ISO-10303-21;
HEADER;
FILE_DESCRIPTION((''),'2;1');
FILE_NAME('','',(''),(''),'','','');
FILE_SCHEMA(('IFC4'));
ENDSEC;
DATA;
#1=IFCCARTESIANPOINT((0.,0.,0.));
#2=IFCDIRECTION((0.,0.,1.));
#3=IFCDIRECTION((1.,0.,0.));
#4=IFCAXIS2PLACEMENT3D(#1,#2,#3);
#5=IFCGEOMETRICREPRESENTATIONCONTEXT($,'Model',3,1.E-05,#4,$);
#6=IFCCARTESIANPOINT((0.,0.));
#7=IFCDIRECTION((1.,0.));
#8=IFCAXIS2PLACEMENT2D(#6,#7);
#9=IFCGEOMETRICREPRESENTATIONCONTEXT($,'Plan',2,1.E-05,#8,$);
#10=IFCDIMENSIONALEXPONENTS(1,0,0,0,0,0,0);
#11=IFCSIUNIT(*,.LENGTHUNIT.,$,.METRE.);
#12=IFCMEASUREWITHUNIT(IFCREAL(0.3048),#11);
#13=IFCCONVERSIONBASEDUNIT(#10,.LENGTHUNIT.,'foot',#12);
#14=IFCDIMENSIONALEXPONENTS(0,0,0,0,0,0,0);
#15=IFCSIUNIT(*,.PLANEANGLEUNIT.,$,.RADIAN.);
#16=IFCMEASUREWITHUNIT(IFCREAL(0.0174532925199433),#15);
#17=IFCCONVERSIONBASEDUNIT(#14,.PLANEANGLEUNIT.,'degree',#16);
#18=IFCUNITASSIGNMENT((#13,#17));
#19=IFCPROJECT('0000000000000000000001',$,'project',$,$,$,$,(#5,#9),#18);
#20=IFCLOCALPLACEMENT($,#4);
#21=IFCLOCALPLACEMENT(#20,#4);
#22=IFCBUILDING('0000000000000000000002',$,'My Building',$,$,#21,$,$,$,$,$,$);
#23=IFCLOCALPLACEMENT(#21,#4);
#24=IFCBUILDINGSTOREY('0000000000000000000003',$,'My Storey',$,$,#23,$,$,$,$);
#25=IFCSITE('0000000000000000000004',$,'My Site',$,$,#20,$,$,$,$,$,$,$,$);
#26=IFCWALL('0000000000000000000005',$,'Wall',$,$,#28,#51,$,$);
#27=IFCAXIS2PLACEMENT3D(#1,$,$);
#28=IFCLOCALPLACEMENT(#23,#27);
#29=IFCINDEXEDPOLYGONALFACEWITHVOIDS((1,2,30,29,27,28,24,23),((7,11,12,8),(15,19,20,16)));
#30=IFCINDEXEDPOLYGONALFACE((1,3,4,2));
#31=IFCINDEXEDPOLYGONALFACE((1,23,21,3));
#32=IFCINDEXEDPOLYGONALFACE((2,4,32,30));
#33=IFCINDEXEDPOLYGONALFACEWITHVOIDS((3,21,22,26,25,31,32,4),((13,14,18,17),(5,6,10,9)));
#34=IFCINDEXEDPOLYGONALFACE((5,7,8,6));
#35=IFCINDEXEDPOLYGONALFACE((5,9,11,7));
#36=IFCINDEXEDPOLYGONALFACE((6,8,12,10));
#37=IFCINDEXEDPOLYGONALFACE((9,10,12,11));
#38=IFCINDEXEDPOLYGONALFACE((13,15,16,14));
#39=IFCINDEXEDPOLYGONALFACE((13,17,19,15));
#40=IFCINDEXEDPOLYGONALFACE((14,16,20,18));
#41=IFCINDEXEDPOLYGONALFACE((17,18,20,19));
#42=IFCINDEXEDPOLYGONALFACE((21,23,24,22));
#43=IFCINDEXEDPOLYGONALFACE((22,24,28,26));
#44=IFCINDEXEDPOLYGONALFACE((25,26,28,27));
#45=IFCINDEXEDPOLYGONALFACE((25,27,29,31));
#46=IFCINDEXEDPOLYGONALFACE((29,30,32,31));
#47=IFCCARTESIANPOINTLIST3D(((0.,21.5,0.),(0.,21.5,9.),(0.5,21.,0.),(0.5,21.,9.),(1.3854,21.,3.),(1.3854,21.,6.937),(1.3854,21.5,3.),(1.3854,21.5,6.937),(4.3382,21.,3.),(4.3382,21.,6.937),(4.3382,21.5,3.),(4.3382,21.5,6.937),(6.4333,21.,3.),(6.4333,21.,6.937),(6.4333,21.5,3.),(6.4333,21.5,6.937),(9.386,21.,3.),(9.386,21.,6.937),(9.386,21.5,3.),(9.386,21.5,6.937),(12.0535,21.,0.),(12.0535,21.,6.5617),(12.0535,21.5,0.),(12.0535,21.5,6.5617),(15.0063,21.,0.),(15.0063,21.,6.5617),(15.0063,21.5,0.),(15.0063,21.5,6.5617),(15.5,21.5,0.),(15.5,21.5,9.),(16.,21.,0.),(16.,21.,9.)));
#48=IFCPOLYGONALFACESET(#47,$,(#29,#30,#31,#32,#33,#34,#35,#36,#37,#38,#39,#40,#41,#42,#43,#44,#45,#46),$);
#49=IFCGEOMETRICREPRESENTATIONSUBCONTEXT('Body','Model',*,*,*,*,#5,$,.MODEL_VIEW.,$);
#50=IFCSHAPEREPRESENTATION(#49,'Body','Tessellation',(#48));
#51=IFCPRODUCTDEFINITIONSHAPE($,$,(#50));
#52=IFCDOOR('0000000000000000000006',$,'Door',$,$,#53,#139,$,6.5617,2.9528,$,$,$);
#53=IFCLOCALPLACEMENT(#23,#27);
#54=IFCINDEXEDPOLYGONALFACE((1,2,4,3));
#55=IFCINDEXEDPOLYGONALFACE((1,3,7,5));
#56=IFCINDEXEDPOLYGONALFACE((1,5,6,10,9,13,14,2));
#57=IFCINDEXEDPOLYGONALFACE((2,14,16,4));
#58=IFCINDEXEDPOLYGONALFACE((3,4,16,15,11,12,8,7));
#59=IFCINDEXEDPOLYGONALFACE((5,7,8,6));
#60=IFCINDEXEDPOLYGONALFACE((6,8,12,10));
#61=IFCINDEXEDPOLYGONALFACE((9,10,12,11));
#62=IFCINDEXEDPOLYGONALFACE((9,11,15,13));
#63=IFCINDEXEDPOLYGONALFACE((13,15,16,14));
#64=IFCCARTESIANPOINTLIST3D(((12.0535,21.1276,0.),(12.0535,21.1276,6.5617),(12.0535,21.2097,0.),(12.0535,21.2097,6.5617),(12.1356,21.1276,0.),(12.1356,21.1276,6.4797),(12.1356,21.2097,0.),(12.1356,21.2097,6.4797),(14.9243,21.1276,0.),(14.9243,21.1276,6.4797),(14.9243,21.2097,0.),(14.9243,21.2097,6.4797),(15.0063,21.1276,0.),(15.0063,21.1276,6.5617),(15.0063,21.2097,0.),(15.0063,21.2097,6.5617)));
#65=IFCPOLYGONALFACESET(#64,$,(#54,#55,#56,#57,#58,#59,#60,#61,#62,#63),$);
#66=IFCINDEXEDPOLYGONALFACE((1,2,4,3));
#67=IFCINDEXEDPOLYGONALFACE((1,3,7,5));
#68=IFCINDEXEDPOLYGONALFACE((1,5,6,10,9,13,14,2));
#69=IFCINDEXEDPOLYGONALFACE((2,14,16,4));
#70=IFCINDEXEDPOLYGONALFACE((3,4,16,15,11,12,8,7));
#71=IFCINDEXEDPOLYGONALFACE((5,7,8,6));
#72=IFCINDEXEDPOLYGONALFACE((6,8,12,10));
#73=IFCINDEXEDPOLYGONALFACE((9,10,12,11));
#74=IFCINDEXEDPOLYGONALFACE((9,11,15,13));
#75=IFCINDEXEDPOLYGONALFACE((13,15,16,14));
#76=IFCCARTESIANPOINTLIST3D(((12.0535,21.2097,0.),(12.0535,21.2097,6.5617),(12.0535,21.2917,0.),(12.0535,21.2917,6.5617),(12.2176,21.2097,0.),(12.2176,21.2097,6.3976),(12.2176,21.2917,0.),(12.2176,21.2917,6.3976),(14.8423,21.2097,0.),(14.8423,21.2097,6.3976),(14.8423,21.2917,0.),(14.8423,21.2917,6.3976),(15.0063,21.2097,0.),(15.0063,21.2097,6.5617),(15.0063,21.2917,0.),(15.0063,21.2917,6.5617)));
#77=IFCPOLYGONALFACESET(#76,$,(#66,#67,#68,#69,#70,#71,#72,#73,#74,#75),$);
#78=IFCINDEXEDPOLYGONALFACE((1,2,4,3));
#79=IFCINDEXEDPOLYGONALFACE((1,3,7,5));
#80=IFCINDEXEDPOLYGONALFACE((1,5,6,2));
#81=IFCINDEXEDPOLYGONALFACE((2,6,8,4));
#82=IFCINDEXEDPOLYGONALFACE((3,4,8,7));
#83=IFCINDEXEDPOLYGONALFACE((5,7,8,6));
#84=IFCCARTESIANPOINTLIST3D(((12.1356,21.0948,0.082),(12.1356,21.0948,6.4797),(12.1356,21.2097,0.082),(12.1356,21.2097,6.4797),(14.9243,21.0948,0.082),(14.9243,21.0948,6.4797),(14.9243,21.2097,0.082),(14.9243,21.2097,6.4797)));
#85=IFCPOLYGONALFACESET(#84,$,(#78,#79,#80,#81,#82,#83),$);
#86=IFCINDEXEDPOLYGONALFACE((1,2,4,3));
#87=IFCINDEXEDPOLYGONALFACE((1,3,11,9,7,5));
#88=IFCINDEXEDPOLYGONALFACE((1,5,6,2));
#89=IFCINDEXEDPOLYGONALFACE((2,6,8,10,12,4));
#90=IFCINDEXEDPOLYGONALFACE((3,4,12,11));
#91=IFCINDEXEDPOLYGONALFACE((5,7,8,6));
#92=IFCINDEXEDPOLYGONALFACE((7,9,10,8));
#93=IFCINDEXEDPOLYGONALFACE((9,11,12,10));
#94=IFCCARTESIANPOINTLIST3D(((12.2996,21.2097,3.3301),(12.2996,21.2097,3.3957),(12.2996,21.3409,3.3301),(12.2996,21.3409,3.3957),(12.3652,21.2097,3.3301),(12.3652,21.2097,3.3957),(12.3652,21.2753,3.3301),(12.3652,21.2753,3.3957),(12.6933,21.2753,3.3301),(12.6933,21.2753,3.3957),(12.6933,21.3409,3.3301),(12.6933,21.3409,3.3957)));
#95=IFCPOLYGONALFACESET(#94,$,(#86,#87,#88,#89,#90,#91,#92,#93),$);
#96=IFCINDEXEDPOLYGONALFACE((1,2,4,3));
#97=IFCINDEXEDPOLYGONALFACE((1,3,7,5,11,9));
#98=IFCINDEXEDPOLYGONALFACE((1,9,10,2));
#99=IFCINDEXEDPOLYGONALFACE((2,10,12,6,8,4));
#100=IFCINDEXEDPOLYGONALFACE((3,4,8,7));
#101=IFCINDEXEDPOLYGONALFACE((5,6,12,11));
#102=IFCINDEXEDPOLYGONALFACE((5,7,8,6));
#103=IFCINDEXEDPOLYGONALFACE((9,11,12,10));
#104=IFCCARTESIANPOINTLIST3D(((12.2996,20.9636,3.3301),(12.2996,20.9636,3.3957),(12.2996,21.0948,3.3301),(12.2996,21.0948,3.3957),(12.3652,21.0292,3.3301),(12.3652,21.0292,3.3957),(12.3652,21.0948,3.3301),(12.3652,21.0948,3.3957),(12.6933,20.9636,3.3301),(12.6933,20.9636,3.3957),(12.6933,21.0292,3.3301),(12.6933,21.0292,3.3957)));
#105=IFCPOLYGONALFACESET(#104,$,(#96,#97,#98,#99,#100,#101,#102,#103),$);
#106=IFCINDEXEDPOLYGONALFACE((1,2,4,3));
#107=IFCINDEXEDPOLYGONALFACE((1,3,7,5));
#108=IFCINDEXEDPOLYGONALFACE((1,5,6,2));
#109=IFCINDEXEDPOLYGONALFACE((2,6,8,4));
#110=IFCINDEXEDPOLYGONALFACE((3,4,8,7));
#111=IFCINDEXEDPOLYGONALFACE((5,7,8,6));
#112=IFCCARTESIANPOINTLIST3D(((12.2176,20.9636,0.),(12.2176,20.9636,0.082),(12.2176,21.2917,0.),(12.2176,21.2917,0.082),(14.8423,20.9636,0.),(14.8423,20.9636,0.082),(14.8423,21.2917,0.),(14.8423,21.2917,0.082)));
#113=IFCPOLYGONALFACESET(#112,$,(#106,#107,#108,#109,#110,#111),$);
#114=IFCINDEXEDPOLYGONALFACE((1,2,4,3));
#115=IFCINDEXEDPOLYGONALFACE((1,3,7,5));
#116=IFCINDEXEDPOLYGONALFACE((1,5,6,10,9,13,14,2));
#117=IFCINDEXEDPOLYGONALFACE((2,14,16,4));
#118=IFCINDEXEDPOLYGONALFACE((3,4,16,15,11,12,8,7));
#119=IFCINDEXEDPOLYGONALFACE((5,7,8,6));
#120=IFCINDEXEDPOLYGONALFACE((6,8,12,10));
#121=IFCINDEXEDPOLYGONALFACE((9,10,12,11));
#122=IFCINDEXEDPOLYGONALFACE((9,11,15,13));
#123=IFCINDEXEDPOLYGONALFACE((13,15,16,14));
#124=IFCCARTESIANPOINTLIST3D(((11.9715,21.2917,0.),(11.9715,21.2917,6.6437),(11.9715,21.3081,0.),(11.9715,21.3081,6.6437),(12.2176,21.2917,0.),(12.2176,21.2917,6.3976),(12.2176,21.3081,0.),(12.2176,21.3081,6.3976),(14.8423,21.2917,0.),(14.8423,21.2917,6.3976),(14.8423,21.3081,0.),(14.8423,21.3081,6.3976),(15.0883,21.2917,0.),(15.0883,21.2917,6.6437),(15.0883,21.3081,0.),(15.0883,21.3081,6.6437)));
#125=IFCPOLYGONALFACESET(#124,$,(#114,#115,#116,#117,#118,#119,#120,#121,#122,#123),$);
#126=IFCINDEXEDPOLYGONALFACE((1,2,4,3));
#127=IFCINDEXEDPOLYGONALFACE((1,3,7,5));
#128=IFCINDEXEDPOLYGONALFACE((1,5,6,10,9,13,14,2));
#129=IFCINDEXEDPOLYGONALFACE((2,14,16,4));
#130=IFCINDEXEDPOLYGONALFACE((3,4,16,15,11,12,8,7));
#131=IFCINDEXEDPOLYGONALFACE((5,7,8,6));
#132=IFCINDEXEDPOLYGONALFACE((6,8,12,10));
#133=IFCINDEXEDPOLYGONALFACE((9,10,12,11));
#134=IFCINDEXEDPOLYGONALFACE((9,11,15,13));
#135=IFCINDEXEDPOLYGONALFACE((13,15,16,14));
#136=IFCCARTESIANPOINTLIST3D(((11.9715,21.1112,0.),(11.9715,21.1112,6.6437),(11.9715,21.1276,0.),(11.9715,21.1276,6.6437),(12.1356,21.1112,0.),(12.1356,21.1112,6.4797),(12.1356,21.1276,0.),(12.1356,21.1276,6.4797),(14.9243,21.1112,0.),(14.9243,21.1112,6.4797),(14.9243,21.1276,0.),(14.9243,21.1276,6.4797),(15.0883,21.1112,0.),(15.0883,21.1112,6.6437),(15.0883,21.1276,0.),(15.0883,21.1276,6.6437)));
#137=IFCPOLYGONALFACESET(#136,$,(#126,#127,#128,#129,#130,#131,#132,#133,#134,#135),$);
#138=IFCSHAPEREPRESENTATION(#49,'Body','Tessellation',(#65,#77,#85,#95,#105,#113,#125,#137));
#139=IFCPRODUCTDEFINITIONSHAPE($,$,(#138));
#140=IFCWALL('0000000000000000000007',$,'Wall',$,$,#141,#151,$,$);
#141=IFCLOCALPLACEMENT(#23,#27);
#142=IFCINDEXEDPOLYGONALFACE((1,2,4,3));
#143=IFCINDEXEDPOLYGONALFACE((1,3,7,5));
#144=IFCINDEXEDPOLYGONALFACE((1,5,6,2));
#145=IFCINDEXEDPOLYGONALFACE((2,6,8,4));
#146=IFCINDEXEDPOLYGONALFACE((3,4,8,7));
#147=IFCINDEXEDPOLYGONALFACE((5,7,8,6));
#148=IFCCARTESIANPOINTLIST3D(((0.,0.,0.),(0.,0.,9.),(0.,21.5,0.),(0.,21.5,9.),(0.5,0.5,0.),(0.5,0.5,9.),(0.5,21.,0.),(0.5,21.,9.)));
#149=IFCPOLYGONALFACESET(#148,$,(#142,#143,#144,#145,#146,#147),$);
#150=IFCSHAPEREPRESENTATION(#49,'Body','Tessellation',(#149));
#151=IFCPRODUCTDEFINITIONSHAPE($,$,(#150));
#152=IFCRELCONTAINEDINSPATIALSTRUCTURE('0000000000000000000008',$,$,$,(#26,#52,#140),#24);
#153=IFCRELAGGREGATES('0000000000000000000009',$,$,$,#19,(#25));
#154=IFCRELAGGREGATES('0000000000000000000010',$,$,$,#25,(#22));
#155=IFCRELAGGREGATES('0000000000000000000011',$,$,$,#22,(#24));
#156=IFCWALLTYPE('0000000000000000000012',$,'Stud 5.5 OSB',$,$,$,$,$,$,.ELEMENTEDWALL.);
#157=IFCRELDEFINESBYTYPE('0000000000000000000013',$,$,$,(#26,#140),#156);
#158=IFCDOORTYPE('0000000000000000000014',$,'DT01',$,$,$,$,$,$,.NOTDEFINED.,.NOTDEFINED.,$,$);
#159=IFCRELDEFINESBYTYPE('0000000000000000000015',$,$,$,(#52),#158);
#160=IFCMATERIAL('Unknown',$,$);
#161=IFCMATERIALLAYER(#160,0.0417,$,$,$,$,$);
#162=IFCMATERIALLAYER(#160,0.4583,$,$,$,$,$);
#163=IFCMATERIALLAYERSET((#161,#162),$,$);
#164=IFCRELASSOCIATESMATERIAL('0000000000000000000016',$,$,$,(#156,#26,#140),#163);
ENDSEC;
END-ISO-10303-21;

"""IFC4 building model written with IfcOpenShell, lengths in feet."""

from ifc_helpers import new_model, entity, si_unit, converted_unit, frame, origin_with_axes, origin_2d_with_axis, place, context, subcontext, project, spatial, line, indexed_curve, outline, extrude, clip, halfspace, shape, source, transform, mapped, material, layer, layer_set, layer_usage, type_object, type_shapes, element, fill, save


model = new_model("IFC4")

# Units and contexts
model_context = context("Model", 3, precision=1e-05, world=origin_with_axes())
plan_context = context("Plan", 2, precision=1e-05, world=origin_2d_with_axis())
body_context_1 = subcontext(model_context, "Body", "Model", "MODEL_VIEW")
body_context_2 = subcontext(plan_context, "Body", "Plan", "PLAN_VIEW")
ifc_project = project(units=[converted_unit("LENGTHUNIT", "foot", entity("IfcReal", 0.3048), si_unit("LENGTHUNIT", "METRE"), dimensions=[1, 0, 0, 0, 0, 0, 0]), converted_unit("PLANEANGLEUNIT", "degree", entity("IfcReal", 0.0174532925199433), si_unit("PLANEANGLEUNIT", "RADIAN"), dimensions=[0, 0, 0, 0, 0, 0, 0])], contexts=[model_context, plan_context])

# Site, building, storey
site_placement = place(None, origin_with_axes())
site = spatial("IfcSite", under=ifc_project, at=site_placement, Name="My Site")
building_placement = place(site_placement, origin_with_axes())
building = spatial("IfcBuilding", under=site, at=building_placement, Name="My Building")
storey_placement = place(building_placement, origin_with_axes())
storey = spatial("IfcBuildingStorey", under=building, at=storey_placement, Name="My Storey")

# Shared definitions
ifc_material = material(Name="Unknown")
shared_shape_1 = source(origin_with_axes(), body_context_1, "Body", "SweptSolid", [
    extrude(outline(indexed_curve([(0.0, 0.0), (2.9528, 0.0), (2.9528, 6.5617), (0.0, 6.5617)], segments=[line(1, 2, 3, 4, 1)])), frame((0.0, -1.9685, 0.0), z_axis=(0.0, -1.0, 0.0), x_axis=(1.0, 0.0, 0.0)), (0.0, 0.0, -1.0), 3.937),
])
door_type = type_object("IfcDoorType", Name="DT01", OperationType="NOTDEFINED", PredefinedType="NOTDEFINED")
shared_shape_2 = source(origin_with_axes(), body_context_1, "Body", "SweptSolid", [
    extrude(outline(indexed_curve([(0.0, 0.0), (0.0, 6.5617), (2.9528, 6.5617), (2.9528, 0.0), (2.8707, 0.0), (2.8707, 6.4797), (0.082, 6.4797), (0.082, 0.0)], segments=[line(1, 2, 3, 4, 5, 6, 7, 8, 1)])), frame((0.0, 0.082, 0.0), z_axis=(0.0, -1.0, 0.0), x_axis=(1.0, 0.0, 0.0)), (0.0, 0.0, -1.0), 0.082),
    extrude(outline(indexed_curve([(0.0, 0.0), (0.0, 6.5617), (2.9528, 6.5617), (2.9528, 0.0), (2.7887, 0.0), (2.7887, 6.3976), (0.164, 6.3976), (0.164, 0.0)], segments=[line(1, 2, 3, 4, 5, 6, 7, 8, 1)])), frame((0.0, 0.0, 0.0), z_axis=(0.0, -1.0, 0.0), x_axis=(1.0, 0.0, 0.0)), (0.0, 0.0, -1.0), 0.082),
    extrude(outline(indexed_curve([(0.0, 0.0), (2.7887, 0.0), (2.7887, 0.1148), (0.0, 0.1148)], segments=[line(1, 2, 3, 4, 1)])), frame((0.082, 0.082, 0.082), z_axis=(0.0, 0.0, 1.0), x_axis=(1.0, 0.0, 0.0)), (0.0, 0.0, 1.0), 6.3976),
    extrude(outline(indexed_curve([(0.0, 0.0), (0.0, -0.1312), (-0.3937, -0.1312), (-0.3937, -0.0656), (-0.0656, -0.0656), (-0.0656, 0.0)], segments=[line(1, 2, 3, 4, 5, 6, 1)])), frame((2.7067, 0.082, 3.3301), z_axis=(0.0, 0.0, 1.0), x_axis=(1.0, 0.0, 0.0)), (0.0, 0.0, 1.0), 0.0656),
    extrude(outline(indexed_curve([(0.0, 0.0), (0.0, 0.1312), (-0.3937, 0.1312), (-0.3937, 0.0656), (-0.0656, 0.0656), (-0.0656, 0.0)], segments=[line(1, 2, 3, 4, 5, 6, 1)])), frame((2.7067, 0.1969, 3.3301), z_axis=(0.0, 0.0, 1.0), x_axis=(1.0, 0.0, 0.0)), (0.0, 0.0, 1.0), 0.0656),
    extrude(outline(indexed_curve([(0.0, 0.0), (2.6247, 0.0), (2.6247, 0.3281), (0.0, 0.3281)], segments=[line(1, 2, 3, 4, 1)])), frame((0.164, 0.0, 0.0), z_axis=(0.0, 0.0, 1.0), x_axis=(1.0, 0.0, 0.0)), (0.0, 0.0, 1.0), 0.082),
    extrude(outline(indexed_curve([(0.0, 0.0), (0.0, 6.6437), (3.1168, 6.6437), (3.1168, 0.0), (2.8707, 0.0), (2.8707, 6.3976), (0.2461, 6.3976), (0.2461, 0.0)], segments=[line(1, 2, 3, 4, 5, 6, 7, 8, 1)])), frame((-0.082, -0.0164, 0.0), z_axis=(0.0, -1.0, 0.0), x_axis=(1.0, 0.0, 0.0)), (0.0, 0.0, -1.0), 0.0164),
    extrude(outline(indexed_curve([(0.0, 0.0), (0.0, 6.6437), (3.1168, 6.6437), (3.1168, 0.0), (2.9528, 0.0), (2.9528, 6.4797), (0.164, 6.4797), (0.164, 0.0)], segments=[line(1, 2, 3, 4, 5, 6, 7, 8, 1)])), frame((-0.082, 0.164, 0.0), z_axis=(0.0, -1.0, 0.0), x_axis=(1.0, 0.0, 0.0)), (0.0, 0.0, -1.0), 0.0164),
])
shared_shape_3 = source(origin_with_axes(), body_context_2, "Body", "Curve2D", [
    entity("IfcIndexedPolyCurve", entity("IfcCartesianPointList2D", [[0.0, 0.0], [0.0, 0.164], [0.082, 0.164], [0.082, 0.082], [0.164, 0.082], [0.164, 0.0]]), [entity("IfcLineIndex", [1, 2, 3, 4, 5, 6, 1])]),
    entity("IfcIndexedPolyCurve", entity("IfcCartesianPointList2D", [[2.9528, 0.0], [2.9528, 0.164], [2.8707, 0.164], [2.8707, 0.082], [2.7887, 0.082], [2.7887, 0.0]]), [entity("IfcLineIndex", [1, 2, 3, 4, 5, 6, 1])]),
    entity("IfcTrimmedCurve", entity("IfcEllipse", entity("IfcAxis2Placement2D", entity("IfcCartesianPoint", [0.1969, 0.164]), entity("IfcDirection", [1.0, 0.0])), 2.6739, 2.7887), [entity("IfcCartesianPoint", [2.8707, 0.164])], [entity("IfcCartesianPoint", [0.1969, 2.9528])], True, "CARTESIAN"),
    entity("IfcIndexedPolyCurve", entity("IfcCartesianPointList2D", [[0.082, 0.164], [0.1969, 0.164], [0.1969, 2.9528], [0.082, 2.9528]]), [entity("IfcLineIndex", [1, 2, 3, 4, 1])]),
])
type_shapes(door_type, [shared_shape_2, shared_shape_3])

# Shared definitions
ifc_layer_1 = layer(ifc_material, 0.0417)
ifc_layer_2 = layer(ifc_material, 0.4583)
ifc_layer_set_1 = layer_set([ifc_layer_1, ifc_layer_2])
wall_type_1 = type_object("IfcWallType", Name="Stud 5.5 OSB", PredefinedType="ELEMENTEDWALL", material=ifc_layer_set_1)
shared_shape_4 = source(origin_with_axes(), body_context_1, "Body", "SweptSolid", [
    extrude(outline(indexed_curve([(0.0, 0.0), (2.9528, 0.0), (2.9528, 3.937), (0.0, 3.937)], segments=[line(1, 2, 3, 4, 1)])), frame((0.0, -1.9685, 0.0), z_axis=(0.0, -1.0, 0.0), x_axis=(1.0, 0.0, 0.0)), (0.0, 0.0, -1.0), 3.937),
])

# Wall, openings, door
ifc_layer_usage_1 = layer_usage(ifc_layer_set_1, "AXIS2", "POSITIVE", 0.0)
wall_1_placement = place(storey_placement, frame((16.0, 21.5, 0.0), z_axis=(0.0, 0.0, 1.0), x_axis=(-1.0, 0.000001, 0.0)))
wall_1 = element("IfcWall", 1, at=wall_1_placement, inside=storey, type_object=wall_type_1, material=ifc_layer_usage_1, Name="Wall", context=body_context_1, shape_type="Clipping", body=[
    clip(clip(extrude(outline(indexed_curve([(0.0, 0.0), (0.0, 0.5), (16.0, 0.5), (16.0, 0.0), (0.0, 0.0)], self_intersect=False)), origin_with_axes(), (0.0, 0.0, 1.0), 9.0), halfspace(frame((16.0, 0.0, 0.0), z_axis=(0.707106, 0.707107, 0.0), x_axis=(0.707107, -0.707106, 0.0)), False)), halfspace(frame((0.5, 0.0, 0.0), z_axis=(-0.707106, -0.707107, 0.0), x_axis=(-0.707107, 0.707106, 0.0)), False)),
])
opening_1_placement = place(wall_1_placement, frame((0.9937, 0.2083, 0.0), z_axis=(0.0, 0.0, 1.0), x_axis=(1.0, 0.0, 0.0)))
opening_1 = element("IfcOpeningElement", 2, at=opening_1_placement, cuts=wall_1, PredefinedType="OPENING", context=body_context_1, shape_type="MappedRepresentation", body=[
    mapped(shared_shape_1, transform((0.0, 0.0, 0.0), x_axis=(1.0, 0.0, 0.0), y_axis=(0.0, 1.0, 0.0), z_axis=(0.0, 0.0, 1.0), scale=1.0)),
])
opening_2_placement = place(wall_1_placement, frame((11.6618, 0.0, 3.0), z_axis=(0.0, 0.0, 1.0), x_axis=(1.0, 0.0, 0.0)))
element("IfcOpeningElement", 3, at=opening_2_placement, cuts=wall_1, PredefinedType="OPENING", context=body_context_1, shape_type="MappedRepresentation", body=[
    mapped(shared_shape_4, transform((0.0, 0.0, 0.0), x_axis=(1.0, 0.0, 0.0), y_axis=(0.0, 1.0, 0.0), z_axis=(0.0, 0.0, 1.0), scale=1.0)),
])
opening_3_placement = place(wall_1_placement, frame((6.614, 0.0, 3.0), z_axis=(0.0, 0.0, 1.0), x_axis=(1.0, 0.0, 0.0)))
element("IfcOpeningElement", 4, at=opening_3_placement, cuts=wall_1, PredefinedType="OPENING", context=body_context_1, shape_type="MappedRepresentation", body=[
    mapped(shared_shape_4, transform((0.0, 0.0, 0.0), x_axis=(1.0, 0.0, 0.0), y_axis=(0.0, 1.0, 0.0), z_axis=(0.0, 0.0, 1.0), scale=1.0)),
])
door_1_placement = place(opening_1_placement, frame((0.0, 0.0, 0.0), z_axis=(0.0, 0.0, 1.0), x_axis=(1.0, 0.0, 0.0)))
door_1 = element("IfcDoor", 5, at=door_1_placement, inside=storey, type_object=door_type, Name="Door", OverallHeight=6.5617, OverallWidth=2.9528, shapes=[
    shape(body_context_1, "Body", "MappedRepresentation", [mapped(shared_shape_2, transform((0.0, 0.0, 0.0), x_axis=(1.0, 0.0, 0.0), y_axis=(0.0, 1.0, 0.0), z_axis=(0.0, 0.0, 1.0), scale=1.0))]),
    shape(body_context_2, "Body", "MappedRepresentation", [mapped(shared_shape_3, transform((0.0, 0.0, 0.0), x_axis=(1.0, 0.0, 0.0), y_axis=(0.0, 1.0, 0.0), z_axis=(0.0, 0.0, 1.0), scale=1.0))]),
])
fill(opening_1, door_1)

# Wall
ifc_layer_usage_2 = layer_usage(ifc_layer_set_1, "AXIS2", "POSITIVE", 0.0)
wall_2_placement = place(storey_placement, frame((0.0, 21.5, 0.0), z_axis=(0.0, 0.0, 1.0), x_axis=(-0.000001, -1.0, 0.0)))
element("IfcWall", 6, at=wall_2_placement, inside=storey, type_object=wall_type_1, material=ifc_layer_usage_2, Name="Wall", context=body_context_1, shape_type="Clipping", body=[
    clip(clip(extrude(outline(indexed_curve([(0.0, 0.0), (0.0, 0.5), (21.5, 0.5), (21.5, 0.0), (0.0, 0.0)], self_intersect=False)), origin_with_axes(), (0.0, 0.0, 1.0), 9.0), halfspace(frame((21.5, 0.0, 0.0), z_axis=(0.707107, 0.707107, 0.0), x_axis=(0.707107, -0.707107, 0.0)), False)), halfspace(frame((0.0, 0.0, 0.0), z_axis=(-0.707107, 0.707106, 0.0), x_axis=(0.707107, 0.707107, 0.0)), False)),
])

save(model, "model.ifc")
